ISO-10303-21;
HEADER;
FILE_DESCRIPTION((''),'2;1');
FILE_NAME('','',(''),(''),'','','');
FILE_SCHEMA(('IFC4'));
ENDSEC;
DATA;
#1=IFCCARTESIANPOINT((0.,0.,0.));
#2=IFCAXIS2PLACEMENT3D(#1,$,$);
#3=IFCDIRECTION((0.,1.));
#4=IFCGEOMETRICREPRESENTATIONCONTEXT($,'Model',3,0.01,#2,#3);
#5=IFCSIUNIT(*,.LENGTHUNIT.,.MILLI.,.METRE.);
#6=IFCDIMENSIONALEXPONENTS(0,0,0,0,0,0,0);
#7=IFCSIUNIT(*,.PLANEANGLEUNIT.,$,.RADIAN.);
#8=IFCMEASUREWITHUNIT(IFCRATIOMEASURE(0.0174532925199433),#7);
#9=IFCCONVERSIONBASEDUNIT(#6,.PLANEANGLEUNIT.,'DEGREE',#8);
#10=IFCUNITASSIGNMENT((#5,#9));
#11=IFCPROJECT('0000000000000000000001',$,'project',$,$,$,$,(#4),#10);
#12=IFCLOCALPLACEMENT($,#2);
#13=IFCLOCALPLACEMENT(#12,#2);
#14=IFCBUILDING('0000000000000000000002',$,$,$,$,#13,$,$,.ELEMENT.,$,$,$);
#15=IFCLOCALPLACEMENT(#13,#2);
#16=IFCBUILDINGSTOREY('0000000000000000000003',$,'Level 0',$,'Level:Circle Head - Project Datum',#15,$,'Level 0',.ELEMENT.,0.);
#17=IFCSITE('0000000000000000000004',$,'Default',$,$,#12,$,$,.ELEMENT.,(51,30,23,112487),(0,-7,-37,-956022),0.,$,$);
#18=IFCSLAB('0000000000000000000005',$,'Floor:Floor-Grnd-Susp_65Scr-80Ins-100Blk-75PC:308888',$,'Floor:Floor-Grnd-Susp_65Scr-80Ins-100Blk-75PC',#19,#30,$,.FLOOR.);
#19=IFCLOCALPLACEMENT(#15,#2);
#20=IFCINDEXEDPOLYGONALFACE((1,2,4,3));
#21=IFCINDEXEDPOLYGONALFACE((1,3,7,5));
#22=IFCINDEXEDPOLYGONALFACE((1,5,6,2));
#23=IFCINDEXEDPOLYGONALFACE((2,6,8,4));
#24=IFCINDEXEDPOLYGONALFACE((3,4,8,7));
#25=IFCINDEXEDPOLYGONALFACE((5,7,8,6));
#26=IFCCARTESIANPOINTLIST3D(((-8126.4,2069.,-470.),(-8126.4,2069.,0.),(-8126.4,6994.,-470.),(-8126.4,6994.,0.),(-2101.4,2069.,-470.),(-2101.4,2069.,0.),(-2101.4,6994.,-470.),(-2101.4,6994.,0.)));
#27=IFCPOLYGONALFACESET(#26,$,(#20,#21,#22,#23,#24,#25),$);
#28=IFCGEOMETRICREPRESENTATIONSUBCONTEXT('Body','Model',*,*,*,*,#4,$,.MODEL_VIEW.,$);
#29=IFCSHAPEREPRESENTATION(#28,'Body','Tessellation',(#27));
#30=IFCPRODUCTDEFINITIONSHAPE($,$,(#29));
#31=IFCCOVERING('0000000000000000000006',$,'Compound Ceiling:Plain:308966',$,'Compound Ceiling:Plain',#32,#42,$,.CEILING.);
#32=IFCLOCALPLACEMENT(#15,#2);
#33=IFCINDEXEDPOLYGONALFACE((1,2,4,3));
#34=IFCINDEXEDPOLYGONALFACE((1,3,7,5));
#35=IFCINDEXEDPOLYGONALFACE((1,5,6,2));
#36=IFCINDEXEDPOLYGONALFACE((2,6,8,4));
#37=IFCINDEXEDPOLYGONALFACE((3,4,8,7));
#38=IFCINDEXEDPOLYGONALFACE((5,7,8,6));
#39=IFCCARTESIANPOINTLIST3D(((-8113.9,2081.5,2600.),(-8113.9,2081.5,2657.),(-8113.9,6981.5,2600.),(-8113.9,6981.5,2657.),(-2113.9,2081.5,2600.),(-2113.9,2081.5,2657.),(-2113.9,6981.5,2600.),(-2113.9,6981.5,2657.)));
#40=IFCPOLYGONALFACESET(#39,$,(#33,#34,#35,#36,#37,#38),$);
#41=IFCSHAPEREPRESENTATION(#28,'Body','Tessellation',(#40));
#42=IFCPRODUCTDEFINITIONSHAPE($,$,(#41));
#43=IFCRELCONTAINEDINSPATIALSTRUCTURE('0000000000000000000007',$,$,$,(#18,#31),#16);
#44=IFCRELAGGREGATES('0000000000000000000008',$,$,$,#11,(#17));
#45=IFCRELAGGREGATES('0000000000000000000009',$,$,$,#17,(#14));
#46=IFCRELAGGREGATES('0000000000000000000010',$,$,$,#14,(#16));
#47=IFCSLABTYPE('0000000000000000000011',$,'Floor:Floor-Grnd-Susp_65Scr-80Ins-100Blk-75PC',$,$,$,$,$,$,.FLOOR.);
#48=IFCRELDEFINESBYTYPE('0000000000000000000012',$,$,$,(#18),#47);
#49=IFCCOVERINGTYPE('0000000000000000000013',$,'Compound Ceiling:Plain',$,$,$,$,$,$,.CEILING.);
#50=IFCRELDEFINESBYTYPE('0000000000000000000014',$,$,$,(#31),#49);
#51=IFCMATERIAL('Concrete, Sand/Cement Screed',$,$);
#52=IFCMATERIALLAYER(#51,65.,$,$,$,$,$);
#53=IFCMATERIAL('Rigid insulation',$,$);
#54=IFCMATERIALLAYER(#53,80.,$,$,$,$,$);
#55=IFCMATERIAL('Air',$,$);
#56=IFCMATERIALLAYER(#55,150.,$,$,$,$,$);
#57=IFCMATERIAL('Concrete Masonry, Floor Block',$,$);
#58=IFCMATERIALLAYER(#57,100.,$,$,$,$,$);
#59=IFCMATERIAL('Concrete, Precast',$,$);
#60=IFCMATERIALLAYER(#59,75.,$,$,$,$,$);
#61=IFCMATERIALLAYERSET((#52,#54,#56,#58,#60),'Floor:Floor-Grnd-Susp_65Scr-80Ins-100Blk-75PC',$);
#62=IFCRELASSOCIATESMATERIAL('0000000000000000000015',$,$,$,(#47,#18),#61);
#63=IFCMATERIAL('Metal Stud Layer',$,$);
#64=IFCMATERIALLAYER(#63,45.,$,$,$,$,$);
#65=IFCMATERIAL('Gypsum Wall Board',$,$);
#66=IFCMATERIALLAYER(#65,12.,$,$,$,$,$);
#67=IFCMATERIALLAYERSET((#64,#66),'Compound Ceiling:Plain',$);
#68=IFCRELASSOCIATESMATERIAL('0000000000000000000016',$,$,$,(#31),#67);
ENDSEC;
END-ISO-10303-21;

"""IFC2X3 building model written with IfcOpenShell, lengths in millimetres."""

from ifc_helpers import new_model, entity, si_unit, converted_unit, direction, frame, frame_2d, origin, origin_2d_with_axis, place, context, subcontext, project, spatial, rectangle, extrude, material, layer, layer_set, layer_usage, type_object, element, save


model = new_model("IFC2X3")

# Units and contexts
model_context = context("Model", 3, precision=0.01, world=origin(), true_north=direction((0.0, 1.0)))
body_context = subcontext(model_context, "Body", "Model", "MODEL_VIEW")
ifc_project = project(units=[si_unit("LENGTHUNIT", "METRE", prefix="MILLI"), converted_unit("PLANEANGLEUNIT", "DEGREE", entity("IfcRatioMeasure", 0.0174532925199433), si_unit("PLANEANGLEUNIT", "RADIAN"), dimensions=[0, 0, 0, 0, 0, 0, 0])], contexts=[model_context])

# Site, building, storey
site_placement = place(None, origin())
site = spatial("IfcSite", under=ifc_project, at=site_placement, Name="Default", CompositionType="ELEMENT", RefLatitude=(51, 30, 23, 112487), RefLongitude=(0, -7, -37, -956022), RefElevation=0.0)
building_placement = place(site_placement, origin())
building = spatial("IfcBuilding", under=site, at=building_placement, CompositionType="ELEMENT")
storey_placement = place(building_placement, origin())
storey = spatial("IfcBuildingStorey", under=building, at=storey_placement, Name="Level 0", ObjectType="Level:Circle Head - Project Datum", LongName="Level 0", CompositionType="ELEMENT", Elevation=0.0)

# Slab
ifc_material_1 = material(Name="Concrete, Sand/Cement Screed")
ifc_layer_1 = layer(ifc_material_1, 65.0)
ifc_material_2 = material(Name="Rigid insulation")
ifc_layer_2 = layer(ifc_material_2, 80.0)
ifc_material_3 = material(Name="Air")
ifc_layer_3 = layer(ifc_material_3, 150.0)
ifc_material_4 = material(Name="Concrete Masonry, Floor Block")
ifc_layer_4 = layer(ifc_material_4, 100.0)
ifc_material_5 = material(Name="Concrete, Precast")
ifc_layer_5 = layer(ifc_material_5, 75.0)
ifc_layer_set_1 = layer_set([ifc_layer_1, ifc_layer_2, ifc_layer_3, ifc_layer_4, ifc_layer_5], Name="Floor:Floor-Grnd-Susp_65Scr-80Ins-100Blk-75PC")
ifc_layer_usage_1 = layer_usage(ifc_layer_set_1, "AXIS3", "POSITIVE", 0.0)
slab_type = type_object("IfcSlabType", Name="Floor:Floor-Grnd-Susp_65Scr-80Ins-100Blk-75PC", PredefinedType="FLOOR", material=ifc_layer_set_1)
slab_placement = place(storey_placement, origin())
element("IfcSlab", 1, at=slab_placement, inside=storey, type_object=slab_type, material=ifc_layer_usage_1, Name="Floor:Floor-Grnd-Susp_65Scr-80Ins-100Blk-75PC:308888", ObjectType="Floor:Floor-Grnd-Susp_65Scr-80Ins-100Blk-75PC", PredefinedType="FLOOR", context=body_context, shape_type="SweptSolid", body=[
    extrude(rectangle(XDim=4925.0, YDim=6025.0, at=frame_2d((0.0, 0.0), x_axis=(1.0, 0.0))), frame((-5113.9, 4531.5, 0.0), z_axis=(0.0, 0.0, -1.0), x_axis=(0.0, 1.0, 0.0)), (0.0, 0.0, 1.0), 470.0),
])

# Covering
ifc_material_6 = material(Name="Metal Stud Layer")
ifc_layer_6 = layer(ifc_material_6, 45.0)
ifc_material_7 = material(Name="Gypsum Wall Board")
ifc_layer_7 = layer(ifc_material_7, 12.0)
ifc_layer_set_2 = layer_set([ifc_layer_6, ifc_layer_7], Name="Compound Ceiling:Plain")
ifc_layer_usage_2 = layer_usage(ifc_layer_set_2, "AXIS3", "POSITIVE", 0.0)
covering_type = type_object("IfcCoveringType", Name="Compound Ceiling:Plain", PredefinedType="CEILING")
covering_placement = place(storey_placement, origin())
element("IfcCovering", 2, at=covering_placement, inside=storey, type_object=covering_type, material=ifc_layer_usage_2, Name="Compound Ceiling:Plain:308966", ObjectType="Compound Ceiling:Plain", PredefinedType="CEILING", context=body_context, shape_type="SweptSolid", body=[
    extrude(rectangle(XDim=4900.0, YDim=6000.0, at=origin_2d_with_axis()), frame((-5113.9, 4531.5, 2600.0), z_axis=(0.0, 0.0, 1.0), x_axis=(0.0, -1.0, 0.0)), (0.0, 0.0, 1.0), 57.0),
])

save(model, "model.ifc")
